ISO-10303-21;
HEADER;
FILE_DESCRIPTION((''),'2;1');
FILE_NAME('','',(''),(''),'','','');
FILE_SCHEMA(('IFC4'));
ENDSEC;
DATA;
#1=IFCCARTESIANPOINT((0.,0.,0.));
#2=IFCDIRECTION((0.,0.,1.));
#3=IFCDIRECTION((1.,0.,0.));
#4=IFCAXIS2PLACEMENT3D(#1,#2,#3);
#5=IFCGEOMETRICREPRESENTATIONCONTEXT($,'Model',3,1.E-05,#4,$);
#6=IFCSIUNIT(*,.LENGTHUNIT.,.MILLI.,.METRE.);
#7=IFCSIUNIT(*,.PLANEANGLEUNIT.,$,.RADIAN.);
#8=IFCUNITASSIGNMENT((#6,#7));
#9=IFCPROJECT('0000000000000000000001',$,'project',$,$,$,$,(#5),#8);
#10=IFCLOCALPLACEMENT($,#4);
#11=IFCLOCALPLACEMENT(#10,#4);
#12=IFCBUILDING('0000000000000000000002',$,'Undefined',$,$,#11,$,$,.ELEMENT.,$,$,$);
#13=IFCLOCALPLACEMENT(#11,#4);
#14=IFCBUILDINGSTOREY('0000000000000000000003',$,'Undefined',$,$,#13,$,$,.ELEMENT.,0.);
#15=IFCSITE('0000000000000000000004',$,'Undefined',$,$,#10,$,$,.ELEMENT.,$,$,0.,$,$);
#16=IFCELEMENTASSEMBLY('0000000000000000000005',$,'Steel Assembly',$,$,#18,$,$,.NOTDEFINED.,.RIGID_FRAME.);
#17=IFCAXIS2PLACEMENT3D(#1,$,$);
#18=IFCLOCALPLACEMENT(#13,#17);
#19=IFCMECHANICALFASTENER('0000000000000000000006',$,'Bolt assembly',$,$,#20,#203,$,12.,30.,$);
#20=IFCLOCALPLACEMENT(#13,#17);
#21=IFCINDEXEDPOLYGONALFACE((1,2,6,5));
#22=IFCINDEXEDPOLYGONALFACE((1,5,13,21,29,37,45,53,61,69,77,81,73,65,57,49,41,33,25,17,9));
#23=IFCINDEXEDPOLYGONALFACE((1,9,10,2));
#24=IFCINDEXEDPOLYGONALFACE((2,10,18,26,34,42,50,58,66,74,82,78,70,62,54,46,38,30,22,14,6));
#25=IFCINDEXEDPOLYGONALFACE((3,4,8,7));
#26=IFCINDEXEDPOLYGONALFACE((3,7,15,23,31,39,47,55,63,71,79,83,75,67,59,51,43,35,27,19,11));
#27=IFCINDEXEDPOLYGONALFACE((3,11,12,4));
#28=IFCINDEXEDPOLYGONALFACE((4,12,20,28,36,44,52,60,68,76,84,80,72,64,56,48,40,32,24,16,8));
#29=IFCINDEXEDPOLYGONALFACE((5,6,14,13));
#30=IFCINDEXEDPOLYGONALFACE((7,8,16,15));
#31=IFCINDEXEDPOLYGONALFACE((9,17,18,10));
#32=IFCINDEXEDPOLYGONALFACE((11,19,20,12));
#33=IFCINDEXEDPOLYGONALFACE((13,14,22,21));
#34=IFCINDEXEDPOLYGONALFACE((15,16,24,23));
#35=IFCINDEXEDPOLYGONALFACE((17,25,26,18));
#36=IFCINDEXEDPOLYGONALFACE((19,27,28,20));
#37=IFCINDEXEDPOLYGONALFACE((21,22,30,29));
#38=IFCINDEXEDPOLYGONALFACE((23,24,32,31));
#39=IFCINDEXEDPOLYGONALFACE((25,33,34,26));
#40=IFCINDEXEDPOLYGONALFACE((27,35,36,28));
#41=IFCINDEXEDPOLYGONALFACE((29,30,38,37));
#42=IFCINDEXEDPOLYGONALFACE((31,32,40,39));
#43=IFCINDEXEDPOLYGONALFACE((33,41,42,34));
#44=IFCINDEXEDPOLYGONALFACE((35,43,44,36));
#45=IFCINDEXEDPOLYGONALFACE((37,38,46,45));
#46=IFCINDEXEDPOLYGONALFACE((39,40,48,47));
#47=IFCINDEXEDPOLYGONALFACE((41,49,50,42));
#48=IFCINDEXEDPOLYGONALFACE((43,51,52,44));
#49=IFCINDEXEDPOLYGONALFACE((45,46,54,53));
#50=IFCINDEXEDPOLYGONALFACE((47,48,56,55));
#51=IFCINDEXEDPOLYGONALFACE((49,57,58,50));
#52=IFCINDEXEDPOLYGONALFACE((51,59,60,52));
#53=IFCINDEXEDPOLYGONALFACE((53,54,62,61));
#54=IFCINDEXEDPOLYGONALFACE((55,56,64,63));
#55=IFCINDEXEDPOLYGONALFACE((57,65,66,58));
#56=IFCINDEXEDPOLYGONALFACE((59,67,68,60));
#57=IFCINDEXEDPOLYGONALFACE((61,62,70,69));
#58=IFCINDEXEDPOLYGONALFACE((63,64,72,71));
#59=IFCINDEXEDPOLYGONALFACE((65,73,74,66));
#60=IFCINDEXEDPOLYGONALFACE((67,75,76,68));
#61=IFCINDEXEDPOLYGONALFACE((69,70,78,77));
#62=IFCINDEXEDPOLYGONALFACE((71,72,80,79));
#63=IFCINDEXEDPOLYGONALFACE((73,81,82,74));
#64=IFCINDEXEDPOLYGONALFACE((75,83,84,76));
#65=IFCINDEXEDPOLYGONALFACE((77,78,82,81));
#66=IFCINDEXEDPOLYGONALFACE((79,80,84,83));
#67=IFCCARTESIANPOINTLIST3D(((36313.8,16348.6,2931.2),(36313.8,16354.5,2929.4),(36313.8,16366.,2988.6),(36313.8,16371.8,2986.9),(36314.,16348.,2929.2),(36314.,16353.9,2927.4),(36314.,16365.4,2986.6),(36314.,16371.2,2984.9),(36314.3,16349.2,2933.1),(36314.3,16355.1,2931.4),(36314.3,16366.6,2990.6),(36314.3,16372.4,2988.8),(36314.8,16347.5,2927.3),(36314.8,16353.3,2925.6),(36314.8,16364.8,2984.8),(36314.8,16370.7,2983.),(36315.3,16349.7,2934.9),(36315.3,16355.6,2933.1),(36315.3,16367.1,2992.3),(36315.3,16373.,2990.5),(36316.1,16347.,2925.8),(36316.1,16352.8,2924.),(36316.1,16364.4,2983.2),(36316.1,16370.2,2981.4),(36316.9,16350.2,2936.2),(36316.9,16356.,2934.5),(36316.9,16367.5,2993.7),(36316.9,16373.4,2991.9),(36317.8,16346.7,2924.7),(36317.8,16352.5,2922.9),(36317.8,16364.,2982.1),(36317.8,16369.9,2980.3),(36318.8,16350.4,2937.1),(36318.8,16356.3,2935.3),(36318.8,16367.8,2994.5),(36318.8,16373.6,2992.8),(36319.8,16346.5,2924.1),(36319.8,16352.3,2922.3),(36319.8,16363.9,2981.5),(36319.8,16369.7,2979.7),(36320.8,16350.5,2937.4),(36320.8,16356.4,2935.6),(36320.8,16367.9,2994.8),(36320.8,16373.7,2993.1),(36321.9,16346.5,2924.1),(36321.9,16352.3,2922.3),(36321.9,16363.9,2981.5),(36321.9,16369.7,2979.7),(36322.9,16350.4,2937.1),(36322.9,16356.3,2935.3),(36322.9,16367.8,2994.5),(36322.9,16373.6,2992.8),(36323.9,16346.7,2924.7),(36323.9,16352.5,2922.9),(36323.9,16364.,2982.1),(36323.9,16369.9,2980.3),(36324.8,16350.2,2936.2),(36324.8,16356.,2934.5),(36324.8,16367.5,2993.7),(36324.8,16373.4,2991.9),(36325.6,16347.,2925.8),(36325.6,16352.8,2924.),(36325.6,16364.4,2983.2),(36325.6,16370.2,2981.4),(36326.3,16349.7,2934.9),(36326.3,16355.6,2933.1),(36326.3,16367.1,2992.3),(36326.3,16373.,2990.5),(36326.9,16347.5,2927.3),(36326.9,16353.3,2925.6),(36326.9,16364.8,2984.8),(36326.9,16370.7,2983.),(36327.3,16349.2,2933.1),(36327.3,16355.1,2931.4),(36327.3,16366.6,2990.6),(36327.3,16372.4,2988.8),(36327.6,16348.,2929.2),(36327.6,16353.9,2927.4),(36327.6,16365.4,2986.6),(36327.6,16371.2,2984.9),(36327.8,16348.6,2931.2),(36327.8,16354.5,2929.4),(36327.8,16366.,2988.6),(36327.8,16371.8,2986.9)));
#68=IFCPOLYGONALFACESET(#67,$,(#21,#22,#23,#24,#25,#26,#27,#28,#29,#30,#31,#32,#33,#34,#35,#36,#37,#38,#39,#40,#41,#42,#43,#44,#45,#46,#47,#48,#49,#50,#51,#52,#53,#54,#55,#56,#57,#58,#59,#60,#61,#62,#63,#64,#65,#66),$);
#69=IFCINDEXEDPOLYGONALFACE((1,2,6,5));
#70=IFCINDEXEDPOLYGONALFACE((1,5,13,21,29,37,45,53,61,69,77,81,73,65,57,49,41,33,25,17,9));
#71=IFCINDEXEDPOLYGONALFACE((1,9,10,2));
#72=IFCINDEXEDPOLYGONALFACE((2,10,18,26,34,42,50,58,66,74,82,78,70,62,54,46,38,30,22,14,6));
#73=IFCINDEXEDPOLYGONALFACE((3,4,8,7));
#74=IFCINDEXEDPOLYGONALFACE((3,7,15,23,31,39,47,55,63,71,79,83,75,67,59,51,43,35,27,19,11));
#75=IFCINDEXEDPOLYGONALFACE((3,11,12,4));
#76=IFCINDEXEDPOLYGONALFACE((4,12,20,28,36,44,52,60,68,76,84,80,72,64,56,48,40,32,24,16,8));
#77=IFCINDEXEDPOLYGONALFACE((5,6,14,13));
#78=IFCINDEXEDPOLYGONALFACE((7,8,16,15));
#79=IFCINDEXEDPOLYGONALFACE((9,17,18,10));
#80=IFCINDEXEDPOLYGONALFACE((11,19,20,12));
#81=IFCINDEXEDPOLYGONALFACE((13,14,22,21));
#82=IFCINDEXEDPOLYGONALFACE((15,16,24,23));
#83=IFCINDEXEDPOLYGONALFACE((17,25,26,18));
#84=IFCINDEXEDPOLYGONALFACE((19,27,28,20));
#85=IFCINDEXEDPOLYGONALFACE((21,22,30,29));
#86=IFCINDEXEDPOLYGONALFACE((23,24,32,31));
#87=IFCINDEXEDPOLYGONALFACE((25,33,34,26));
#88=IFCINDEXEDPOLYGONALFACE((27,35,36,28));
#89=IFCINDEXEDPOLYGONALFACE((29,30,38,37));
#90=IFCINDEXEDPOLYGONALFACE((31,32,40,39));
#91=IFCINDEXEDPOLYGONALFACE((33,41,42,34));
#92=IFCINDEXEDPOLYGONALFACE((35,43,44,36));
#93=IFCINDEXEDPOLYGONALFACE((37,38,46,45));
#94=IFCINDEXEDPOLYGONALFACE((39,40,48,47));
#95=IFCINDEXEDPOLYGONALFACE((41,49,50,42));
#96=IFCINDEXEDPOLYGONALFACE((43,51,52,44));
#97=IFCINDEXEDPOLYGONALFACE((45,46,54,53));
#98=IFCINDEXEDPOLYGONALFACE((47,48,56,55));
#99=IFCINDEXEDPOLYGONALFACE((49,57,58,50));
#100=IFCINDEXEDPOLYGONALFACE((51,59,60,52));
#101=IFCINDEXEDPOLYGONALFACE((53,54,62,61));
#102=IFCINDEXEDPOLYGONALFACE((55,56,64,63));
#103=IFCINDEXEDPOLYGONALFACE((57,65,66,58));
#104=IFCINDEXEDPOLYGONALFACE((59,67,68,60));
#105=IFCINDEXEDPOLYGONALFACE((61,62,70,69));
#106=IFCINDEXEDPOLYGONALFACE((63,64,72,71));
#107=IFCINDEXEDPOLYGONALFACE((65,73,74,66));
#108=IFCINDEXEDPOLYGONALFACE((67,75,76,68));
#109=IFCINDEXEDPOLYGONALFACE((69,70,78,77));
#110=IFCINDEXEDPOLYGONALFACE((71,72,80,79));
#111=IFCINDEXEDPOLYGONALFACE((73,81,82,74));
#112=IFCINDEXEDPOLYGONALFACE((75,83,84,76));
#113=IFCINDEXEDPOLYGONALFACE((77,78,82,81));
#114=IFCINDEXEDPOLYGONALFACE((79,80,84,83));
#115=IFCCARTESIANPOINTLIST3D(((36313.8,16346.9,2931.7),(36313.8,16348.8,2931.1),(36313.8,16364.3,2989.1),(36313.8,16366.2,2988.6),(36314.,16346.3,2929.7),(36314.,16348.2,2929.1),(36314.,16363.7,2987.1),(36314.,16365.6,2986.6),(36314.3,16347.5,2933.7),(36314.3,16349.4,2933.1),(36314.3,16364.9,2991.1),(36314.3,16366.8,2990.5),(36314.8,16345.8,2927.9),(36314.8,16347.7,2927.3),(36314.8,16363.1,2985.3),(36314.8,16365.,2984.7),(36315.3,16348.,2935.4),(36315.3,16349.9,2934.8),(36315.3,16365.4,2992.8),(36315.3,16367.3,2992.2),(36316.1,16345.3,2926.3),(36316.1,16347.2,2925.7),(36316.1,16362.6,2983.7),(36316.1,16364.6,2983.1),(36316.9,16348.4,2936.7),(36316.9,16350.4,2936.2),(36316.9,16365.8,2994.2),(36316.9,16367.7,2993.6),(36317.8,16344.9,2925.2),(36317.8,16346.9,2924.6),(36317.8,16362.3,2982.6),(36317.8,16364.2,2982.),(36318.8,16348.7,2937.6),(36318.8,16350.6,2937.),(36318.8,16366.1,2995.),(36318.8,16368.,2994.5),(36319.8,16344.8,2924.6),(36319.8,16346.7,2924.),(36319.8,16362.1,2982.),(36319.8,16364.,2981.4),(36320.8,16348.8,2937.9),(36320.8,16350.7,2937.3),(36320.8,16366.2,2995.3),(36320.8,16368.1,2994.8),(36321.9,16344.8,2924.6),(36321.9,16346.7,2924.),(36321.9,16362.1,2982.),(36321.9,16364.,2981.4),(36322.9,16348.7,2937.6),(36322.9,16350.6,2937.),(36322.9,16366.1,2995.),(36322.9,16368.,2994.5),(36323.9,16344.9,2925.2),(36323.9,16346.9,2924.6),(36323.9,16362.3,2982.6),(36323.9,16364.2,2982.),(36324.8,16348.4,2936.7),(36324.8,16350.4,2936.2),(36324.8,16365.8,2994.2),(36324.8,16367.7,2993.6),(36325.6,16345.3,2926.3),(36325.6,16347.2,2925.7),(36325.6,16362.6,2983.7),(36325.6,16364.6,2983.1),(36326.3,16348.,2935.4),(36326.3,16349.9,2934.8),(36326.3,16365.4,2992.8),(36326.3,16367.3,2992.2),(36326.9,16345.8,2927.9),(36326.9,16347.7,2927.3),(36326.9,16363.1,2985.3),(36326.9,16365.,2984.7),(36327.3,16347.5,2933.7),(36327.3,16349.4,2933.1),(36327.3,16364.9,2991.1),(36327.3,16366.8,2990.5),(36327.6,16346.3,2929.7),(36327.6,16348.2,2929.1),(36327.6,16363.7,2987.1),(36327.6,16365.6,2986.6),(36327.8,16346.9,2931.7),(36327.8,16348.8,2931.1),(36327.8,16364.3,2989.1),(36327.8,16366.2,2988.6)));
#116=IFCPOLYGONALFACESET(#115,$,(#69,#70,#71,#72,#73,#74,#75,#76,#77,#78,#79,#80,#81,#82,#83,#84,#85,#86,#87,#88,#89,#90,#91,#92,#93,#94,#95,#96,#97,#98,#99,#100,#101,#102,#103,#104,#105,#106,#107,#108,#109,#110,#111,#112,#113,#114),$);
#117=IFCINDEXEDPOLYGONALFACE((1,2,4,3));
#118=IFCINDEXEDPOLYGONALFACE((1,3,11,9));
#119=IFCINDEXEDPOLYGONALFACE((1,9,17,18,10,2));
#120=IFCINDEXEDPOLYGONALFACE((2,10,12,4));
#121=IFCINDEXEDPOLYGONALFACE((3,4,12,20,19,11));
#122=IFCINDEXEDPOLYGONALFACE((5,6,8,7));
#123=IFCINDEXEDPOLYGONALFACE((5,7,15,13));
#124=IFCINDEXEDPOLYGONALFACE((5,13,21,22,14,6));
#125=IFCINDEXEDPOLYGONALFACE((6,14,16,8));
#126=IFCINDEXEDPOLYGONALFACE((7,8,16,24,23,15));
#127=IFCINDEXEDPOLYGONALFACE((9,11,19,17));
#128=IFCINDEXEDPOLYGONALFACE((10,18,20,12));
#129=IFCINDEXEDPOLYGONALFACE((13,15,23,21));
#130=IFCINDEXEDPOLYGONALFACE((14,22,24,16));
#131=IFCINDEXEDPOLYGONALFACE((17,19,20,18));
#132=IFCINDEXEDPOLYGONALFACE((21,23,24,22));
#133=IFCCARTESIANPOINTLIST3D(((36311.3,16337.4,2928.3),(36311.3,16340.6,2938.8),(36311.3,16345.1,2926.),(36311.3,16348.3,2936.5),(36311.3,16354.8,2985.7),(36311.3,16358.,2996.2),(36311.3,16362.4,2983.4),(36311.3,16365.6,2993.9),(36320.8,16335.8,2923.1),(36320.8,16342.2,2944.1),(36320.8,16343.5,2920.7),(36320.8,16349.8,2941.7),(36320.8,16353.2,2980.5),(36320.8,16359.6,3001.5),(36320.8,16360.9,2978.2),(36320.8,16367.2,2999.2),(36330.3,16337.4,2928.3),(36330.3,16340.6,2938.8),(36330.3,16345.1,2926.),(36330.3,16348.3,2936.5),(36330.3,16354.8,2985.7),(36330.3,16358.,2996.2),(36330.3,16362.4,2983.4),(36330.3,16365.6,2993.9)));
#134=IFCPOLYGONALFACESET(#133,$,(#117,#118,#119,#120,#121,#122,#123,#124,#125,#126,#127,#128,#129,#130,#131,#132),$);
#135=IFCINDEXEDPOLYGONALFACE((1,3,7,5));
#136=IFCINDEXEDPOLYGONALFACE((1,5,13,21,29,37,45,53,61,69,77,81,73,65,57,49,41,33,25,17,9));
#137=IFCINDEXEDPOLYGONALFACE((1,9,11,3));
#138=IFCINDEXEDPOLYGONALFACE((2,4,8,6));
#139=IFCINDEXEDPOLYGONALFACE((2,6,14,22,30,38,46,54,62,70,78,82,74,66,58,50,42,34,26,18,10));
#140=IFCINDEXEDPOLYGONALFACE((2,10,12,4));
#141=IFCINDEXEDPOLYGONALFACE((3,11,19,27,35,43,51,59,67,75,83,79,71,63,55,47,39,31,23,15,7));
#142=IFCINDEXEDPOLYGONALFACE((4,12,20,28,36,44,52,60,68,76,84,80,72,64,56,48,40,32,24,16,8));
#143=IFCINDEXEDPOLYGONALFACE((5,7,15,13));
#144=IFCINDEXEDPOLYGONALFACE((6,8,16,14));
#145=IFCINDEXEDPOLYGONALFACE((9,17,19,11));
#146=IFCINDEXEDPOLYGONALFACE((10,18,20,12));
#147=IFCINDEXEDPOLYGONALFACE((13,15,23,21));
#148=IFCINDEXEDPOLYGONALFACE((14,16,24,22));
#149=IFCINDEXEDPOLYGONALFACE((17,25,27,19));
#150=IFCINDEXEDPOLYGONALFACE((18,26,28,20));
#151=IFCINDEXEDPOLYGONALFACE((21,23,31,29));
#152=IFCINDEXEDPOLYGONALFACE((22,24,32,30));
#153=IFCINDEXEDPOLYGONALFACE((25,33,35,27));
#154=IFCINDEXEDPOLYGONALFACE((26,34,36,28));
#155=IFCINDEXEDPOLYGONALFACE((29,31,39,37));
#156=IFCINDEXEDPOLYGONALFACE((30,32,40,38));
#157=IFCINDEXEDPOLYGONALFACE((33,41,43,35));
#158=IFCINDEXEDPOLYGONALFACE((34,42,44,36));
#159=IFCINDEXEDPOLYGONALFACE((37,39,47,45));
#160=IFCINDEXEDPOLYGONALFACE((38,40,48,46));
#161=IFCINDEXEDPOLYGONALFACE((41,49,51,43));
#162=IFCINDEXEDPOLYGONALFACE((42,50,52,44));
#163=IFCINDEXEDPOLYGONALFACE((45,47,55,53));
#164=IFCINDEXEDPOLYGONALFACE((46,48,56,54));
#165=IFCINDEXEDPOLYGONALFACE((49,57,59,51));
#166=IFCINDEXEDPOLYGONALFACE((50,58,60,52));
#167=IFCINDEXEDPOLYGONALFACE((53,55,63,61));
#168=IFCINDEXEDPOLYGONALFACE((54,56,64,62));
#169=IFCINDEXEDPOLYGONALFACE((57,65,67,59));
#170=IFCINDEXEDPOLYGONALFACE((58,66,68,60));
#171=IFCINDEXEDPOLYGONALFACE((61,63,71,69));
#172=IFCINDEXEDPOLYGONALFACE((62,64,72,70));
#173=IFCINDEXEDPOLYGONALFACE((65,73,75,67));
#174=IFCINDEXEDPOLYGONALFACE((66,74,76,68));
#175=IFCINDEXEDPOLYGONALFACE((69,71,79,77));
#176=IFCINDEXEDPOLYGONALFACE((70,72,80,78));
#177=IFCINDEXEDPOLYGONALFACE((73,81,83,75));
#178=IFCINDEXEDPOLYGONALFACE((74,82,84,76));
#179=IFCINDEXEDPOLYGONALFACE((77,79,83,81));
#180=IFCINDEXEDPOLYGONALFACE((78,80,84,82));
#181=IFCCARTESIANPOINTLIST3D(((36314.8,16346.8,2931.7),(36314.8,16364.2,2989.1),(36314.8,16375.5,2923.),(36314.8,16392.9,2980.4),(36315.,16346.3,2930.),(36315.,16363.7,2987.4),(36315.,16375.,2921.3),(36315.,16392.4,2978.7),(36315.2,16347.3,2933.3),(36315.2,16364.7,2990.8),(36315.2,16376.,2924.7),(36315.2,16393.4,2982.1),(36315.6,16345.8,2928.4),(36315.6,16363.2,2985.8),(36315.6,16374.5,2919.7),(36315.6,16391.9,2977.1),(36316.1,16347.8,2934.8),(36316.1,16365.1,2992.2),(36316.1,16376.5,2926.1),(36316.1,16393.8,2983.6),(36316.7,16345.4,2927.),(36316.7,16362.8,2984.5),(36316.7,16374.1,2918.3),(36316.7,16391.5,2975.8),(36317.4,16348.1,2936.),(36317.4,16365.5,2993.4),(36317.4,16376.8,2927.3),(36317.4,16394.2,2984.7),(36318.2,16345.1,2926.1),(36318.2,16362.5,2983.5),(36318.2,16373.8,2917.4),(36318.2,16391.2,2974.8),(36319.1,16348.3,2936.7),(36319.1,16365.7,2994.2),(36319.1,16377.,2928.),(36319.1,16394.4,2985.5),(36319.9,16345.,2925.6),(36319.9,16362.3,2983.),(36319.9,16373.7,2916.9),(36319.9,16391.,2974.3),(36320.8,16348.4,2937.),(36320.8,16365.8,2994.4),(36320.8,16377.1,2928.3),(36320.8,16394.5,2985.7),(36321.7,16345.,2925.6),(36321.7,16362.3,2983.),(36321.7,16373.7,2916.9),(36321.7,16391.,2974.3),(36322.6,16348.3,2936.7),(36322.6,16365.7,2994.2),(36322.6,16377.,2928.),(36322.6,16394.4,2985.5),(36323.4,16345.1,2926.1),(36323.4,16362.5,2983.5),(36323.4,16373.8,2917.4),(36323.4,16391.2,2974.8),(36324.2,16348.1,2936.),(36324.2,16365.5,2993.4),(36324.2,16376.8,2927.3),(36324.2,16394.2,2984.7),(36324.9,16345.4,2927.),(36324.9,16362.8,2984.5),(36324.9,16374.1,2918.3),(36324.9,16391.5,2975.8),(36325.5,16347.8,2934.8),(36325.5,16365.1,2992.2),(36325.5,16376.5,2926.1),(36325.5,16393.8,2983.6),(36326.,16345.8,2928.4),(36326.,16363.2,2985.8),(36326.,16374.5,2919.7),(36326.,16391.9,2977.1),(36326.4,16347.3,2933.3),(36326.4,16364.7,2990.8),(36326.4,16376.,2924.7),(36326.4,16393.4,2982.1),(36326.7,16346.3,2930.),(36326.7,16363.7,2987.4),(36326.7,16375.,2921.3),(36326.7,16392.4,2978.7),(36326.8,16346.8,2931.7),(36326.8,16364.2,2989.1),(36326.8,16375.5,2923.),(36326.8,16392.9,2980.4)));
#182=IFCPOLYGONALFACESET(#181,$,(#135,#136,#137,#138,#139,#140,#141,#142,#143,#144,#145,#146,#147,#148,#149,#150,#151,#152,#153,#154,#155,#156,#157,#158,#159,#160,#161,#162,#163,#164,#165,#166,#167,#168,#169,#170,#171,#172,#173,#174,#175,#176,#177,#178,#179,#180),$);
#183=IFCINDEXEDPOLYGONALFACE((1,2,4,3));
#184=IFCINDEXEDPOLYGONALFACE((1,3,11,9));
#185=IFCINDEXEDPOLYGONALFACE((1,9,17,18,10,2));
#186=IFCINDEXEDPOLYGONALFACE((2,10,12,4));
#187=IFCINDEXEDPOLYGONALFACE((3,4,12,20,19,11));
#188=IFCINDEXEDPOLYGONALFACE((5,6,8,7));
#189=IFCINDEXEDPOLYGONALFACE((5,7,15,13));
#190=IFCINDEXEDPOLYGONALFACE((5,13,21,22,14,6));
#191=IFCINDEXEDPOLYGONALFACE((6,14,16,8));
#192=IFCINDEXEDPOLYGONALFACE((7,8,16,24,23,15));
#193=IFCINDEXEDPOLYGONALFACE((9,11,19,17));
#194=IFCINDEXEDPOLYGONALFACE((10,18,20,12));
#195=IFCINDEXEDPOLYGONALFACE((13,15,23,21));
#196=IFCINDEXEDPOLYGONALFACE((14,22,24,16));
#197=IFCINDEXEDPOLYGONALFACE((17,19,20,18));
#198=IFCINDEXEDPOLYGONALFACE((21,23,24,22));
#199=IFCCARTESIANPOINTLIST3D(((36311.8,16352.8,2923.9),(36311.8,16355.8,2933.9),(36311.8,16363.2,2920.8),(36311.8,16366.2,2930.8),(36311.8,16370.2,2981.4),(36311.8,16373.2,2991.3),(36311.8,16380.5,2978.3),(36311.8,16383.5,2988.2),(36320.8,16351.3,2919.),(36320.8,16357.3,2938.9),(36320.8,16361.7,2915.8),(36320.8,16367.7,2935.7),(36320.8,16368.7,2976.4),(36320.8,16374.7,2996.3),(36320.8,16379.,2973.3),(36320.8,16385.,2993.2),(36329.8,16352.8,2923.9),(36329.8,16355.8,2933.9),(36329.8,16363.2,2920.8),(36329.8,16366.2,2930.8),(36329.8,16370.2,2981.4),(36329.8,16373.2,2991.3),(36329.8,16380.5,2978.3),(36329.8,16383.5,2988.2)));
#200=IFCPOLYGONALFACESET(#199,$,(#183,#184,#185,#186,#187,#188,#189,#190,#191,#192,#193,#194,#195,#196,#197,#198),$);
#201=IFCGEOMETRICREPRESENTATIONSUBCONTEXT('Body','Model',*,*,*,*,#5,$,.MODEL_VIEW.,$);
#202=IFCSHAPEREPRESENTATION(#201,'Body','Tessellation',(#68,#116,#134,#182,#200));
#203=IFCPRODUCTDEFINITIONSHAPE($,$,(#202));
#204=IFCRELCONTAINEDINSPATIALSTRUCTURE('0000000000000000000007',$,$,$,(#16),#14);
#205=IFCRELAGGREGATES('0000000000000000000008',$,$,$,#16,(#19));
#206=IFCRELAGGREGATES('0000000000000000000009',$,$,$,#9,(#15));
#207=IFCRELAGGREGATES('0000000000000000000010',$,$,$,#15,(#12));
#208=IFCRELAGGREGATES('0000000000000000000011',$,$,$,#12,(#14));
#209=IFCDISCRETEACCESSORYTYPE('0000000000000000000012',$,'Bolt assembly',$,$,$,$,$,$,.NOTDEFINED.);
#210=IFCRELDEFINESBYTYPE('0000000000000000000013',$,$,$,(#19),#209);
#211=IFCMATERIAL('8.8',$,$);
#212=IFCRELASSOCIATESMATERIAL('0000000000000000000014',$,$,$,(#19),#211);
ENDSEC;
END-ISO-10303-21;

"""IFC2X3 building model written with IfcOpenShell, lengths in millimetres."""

from ifc_helpers import new_model, si_unit, frame, origin_with_axes, origin_2d_with_axis, place, context, subcontext, project, spatial, polyline, circle, outline, extrude, source, transform, mapped, material, type_object, element, aggregate, save


model = new_model("IFC2X3")

# Units and contexts
model_context = context("Model", 3, precision=1e-05, world=origin_with_axes())
body_context = subcontext(model_context, "Body", "Model", "MODEL_VIEW")
ifc_project = project(units=[si_unit("LENGTHUNIT", "METRE", prefix="MILLI"), si_unit("PLANEANGLEUNIT", "RADIAN")], contexts=[model_context])

# Site, building, storey
site_placement = place(None, origin_with_axes())
site = spatial("IfcSite", under=ifc_project, at=site_placement, Name="Undefined", CompositionType="ELEMENT", RefElevation=0.0)
building_placement = place(site_placement, origin_with_axes())
building = spatial("IfcBuilding", under=site, at=building_placement, Name="Undefined", CompositionType="ELEMENT")
storey_placement = place(building_placement, origin_with_axes())
storey = spatial("IfcBuildingStorey", under=building, at=storey_placement, Name="Undefined", CompositionType="ELEMENT", Elevation=0.0)

# Element assembly
assembly_1_placement = place(storey_placement, origin_with_axes())
assembly_1 = element("IfcElementAssembly", 1, at=assembly_1_placement, inside=storey, Name="Steel Assembly", AssemblyPlace="NOTDEFINED", PredefinedType="RIGID_FRAME")

# Shared definitions
discrete_accessory_type_1 = type_object("IfcDiscreteAccessoryType", Name="Bolt assembly")

# Shared definitions
ifc_material_1 = material(Name="8.8")

# Mechanical fastener
shared_shape_1 = source(origin_with_axes(), body_context, "Body", "SweptSolid", [
    extrude(circle(Radius=7.0, at=origin_2d_with_axis()), frame((0.0, -3.1, 0.0), z_axis=(0.0, 1.0, 0.0), x_axis=(1.0, 0.0, 0.0)), (0.0, 0.0, 1.0), 6.1),
    extrude(circle(Radius=7.0, at=origin_2d_with_axis()), frame((0.0, -4.9, 0.0), z_axis=(0.0, 1.0, 0.0), x_axis=(1.0, 0.0, 0.0)), (0.0, 0.0, 1.0), 2.0),
    extrude(outline(polyline([(11.0, 0.0), (5.5, 9.5), (-5.5, 9.5), (-11.0, 0.0), (-5.5, -9.5), (5.5, -9.5), (11.0, 0.0)])), frame((0.0, -13.0, 0.0), z_axis=(0.0, 1.0, 0.0), x_axis=(1.0, 0.0, 0.0)), (0.0, 0.0, 1.0), 8.0),
    extrude(circle(Radius=6.0, at=origin_2d_with_axis()), frame((0.0, -5.0, 0.0), z_axis=(0.0, 1.0, 0.0), x_axis=(1.0, 0.0, 0.0)), (0.0, 0.0, 1.0), 30.0),
    extrude(outline(polyline([(10.4, 0.0), (5.2, 9.0), (-5.2, 9.0), (-10.4, 0.0), (-5.2, -9.0), (5.2, -9.0), (10.4, 0.0)])), frame((0.0, 3.0, 0.0), z_axis=(0.0, 1.0, 0.0), x_axis=(1.0, 0.0, 0.0)), (0.0, 0.0, 1.0), 10.8),
])
mechanical_fastener_1_placement = place(assembly_1_placement, frame((36365.8, 16338.4, 2886.7), z_axis=(-1.0, 0.0, 0.0), x_axis=(0.0, 0.289497, 0.957179)))
mechanical_fastener_1 = element("IfcMechanicalFastener", 2, at=mechanical_fastener_1_placement, type_object=discrete_accessory_type_1, material=ifc_material_1, Name="Bolt assembly", NominalDiameter=12.0, NominalLength=30.0, context=body_context, shape_type="MappedRepresentation", body=[
    mapped(shared_shape_1, transform((45.0, 0.0, 45.0))),
    mapped(shared_shape_1, transform((105.0, 0.0, 45.0))),
])
aggregate(assembly_1, [mechanical_fastener_1])

save(model, "model.ifc")
